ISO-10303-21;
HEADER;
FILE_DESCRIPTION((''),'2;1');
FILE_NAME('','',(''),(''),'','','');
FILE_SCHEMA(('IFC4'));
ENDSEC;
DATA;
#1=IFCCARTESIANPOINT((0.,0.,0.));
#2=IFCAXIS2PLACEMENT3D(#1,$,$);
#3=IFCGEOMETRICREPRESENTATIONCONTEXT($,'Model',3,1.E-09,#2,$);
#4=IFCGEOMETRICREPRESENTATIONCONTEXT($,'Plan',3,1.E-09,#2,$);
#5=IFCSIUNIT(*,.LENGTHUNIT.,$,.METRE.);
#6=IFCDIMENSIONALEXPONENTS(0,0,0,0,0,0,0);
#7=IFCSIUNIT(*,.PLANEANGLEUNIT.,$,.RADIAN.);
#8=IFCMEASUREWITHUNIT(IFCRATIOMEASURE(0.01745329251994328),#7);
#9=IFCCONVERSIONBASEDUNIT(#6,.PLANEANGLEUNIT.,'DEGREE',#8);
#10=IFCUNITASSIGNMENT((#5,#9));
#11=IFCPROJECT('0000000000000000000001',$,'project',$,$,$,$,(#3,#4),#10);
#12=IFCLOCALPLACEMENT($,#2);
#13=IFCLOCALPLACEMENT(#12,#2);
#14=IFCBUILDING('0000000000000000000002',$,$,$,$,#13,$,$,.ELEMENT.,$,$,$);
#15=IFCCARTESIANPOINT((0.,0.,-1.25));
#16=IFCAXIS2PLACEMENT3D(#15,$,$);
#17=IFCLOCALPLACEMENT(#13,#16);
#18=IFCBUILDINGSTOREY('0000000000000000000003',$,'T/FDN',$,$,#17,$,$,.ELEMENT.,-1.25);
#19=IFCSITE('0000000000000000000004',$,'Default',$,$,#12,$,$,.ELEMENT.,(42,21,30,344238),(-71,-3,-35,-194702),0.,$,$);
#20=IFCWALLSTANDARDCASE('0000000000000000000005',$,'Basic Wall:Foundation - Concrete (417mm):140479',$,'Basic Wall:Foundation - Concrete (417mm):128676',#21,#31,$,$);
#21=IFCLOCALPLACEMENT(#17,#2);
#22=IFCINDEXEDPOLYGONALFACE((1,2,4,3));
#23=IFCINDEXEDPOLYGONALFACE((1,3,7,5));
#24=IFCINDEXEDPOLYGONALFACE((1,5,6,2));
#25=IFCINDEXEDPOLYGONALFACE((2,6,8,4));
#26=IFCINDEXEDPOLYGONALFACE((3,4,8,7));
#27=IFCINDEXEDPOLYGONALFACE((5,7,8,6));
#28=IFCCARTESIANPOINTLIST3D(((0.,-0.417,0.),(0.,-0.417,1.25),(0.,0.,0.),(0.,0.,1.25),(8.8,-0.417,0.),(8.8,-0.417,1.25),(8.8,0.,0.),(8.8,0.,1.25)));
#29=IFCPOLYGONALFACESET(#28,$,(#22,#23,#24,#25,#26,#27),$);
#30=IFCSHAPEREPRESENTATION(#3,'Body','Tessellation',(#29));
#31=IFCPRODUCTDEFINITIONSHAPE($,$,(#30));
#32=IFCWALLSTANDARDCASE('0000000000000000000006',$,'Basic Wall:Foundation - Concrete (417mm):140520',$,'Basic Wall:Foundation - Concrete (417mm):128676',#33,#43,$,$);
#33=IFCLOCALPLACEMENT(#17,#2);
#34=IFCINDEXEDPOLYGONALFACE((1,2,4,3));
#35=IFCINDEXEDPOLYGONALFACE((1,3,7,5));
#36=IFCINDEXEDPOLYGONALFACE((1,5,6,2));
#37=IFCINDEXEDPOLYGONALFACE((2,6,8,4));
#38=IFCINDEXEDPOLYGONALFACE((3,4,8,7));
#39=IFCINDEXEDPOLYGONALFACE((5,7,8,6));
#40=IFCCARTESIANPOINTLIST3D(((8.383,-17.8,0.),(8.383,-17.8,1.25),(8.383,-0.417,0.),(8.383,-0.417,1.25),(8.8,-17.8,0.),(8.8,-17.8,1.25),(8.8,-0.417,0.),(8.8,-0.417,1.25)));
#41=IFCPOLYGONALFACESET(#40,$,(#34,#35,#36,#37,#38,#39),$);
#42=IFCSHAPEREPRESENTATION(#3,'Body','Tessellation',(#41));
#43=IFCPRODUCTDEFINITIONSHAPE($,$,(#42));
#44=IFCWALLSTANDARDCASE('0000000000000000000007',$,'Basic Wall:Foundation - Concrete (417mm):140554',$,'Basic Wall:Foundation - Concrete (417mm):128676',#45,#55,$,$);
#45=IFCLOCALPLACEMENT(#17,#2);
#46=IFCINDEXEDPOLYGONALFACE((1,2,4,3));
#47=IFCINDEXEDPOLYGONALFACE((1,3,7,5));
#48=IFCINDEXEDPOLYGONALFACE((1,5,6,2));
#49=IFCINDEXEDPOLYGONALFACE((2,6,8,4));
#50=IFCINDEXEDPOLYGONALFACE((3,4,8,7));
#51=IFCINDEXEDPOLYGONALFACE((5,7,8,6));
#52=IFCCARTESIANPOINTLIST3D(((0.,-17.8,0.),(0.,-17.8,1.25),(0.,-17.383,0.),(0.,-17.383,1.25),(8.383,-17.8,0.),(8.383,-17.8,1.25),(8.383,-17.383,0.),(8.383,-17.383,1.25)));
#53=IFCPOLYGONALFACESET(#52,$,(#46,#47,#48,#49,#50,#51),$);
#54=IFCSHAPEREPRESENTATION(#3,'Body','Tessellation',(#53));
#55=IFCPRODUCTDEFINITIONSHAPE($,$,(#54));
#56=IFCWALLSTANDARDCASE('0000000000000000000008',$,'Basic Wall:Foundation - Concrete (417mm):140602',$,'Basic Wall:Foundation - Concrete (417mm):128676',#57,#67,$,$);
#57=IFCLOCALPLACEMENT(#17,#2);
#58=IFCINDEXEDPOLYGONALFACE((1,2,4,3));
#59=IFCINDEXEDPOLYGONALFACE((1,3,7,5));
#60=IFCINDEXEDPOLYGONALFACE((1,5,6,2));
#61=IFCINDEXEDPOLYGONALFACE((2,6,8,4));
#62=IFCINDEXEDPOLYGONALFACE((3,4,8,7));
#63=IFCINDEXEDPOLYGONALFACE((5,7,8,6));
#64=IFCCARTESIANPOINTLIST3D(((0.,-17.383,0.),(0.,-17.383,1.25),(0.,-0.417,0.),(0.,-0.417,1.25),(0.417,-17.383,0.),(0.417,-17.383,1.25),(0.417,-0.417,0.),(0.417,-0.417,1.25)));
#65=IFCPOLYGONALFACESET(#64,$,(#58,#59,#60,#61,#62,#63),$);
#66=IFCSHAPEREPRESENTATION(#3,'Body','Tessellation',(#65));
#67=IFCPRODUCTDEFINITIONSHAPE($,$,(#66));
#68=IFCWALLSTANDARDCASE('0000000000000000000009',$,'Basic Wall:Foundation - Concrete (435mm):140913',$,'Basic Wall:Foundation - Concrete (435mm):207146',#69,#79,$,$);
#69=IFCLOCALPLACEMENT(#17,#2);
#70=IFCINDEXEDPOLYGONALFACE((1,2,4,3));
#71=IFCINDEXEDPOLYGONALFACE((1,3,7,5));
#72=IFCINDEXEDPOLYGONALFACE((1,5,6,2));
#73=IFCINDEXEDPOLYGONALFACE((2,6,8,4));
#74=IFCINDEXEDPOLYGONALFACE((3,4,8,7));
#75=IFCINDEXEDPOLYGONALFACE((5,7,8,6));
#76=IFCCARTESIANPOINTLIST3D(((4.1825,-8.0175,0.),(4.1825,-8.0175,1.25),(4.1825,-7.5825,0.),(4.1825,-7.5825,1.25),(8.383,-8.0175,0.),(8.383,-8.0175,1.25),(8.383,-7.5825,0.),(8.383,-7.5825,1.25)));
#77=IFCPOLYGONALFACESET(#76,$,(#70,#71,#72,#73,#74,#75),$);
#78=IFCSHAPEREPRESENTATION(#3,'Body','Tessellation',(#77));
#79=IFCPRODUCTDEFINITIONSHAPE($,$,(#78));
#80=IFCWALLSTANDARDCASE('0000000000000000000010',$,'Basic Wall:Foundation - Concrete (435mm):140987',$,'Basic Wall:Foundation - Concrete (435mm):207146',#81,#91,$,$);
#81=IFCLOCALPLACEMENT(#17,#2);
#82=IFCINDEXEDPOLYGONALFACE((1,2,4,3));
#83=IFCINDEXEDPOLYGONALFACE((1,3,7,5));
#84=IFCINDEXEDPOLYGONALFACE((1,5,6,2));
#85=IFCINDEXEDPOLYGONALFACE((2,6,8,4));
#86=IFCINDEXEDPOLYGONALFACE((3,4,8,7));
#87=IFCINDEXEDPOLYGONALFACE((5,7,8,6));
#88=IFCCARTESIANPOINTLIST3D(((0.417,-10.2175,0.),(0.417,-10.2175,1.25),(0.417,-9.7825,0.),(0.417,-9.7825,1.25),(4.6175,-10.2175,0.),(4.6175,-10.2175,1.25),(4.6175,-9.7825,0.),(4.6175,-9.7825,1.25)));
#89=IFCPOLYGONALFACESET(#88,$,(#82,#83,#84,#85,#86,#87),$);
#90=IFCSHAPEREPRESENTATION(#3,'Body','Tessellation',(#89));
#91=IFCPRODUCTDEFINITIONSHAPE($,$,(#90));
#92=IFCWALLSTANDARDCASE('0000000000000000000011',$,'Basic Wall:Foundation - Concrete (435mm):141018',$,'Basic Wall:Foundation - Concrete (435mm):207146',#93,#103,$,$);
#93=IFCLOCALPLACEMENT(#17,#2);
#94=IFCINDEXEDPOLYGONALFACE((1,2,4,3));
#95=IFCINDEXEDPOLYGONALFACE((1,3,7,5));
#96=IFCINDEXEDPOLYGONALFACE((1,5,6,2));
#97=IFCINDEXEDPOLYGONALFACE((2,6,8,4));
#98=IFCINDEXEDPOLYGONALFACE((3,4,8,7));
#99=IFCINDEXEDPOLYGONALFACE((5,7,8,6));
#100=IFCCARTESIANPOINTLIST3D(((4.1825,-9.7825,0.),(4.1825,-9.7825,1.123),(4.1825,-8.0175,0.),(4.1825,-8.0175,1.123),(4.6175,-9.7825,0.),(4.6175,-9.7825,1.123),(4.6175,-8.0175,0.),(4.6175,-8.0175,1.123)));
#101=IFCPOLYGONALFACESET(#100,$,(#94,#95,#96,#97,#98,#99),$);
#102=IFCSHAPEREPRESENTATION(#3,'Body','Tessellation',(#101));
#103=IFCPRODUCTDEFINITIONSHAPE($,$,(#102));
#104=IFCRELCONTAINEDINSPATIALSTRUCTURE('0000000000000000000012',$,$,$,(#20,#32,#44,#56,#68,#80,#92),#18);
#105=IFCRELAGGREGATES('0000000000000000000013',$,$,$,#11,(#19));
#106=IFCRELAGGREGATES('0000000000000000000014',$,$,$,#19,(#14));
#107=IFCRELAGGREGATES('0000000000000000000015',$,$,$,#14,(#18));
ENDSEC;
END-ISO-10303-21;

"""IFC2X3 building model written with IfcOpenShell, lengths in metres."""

from ifc_helpers import new_model, entity, si_unit, converted_unit, frame, frame_2d, origin, place, context, project, spatial, rectangle, extrude, element, save


model = new_model("IFC2X3")

# Units and contexts
model_context = context("Model", 3, precision=1e-09, world=origin())
plan_context = context("Plan", 3, precision=1e-09, world=origin())
ifc_project = project(units=[si_unit("LENGTHUNIT", "METRE"), converted_unit("PLANEANGLEUNIT", "DEGREE", entity("IfcRatioMeasure", 0.01745329251994328), si_unit("PLANEANGLEUNIT", "RADIAN"), dimensions=[0, 0, 0, 0, 0, 0, 0])], contexts=[model_context, plan_context])

# Site, building, storey
site_placement = place(None, origin())
site = spatial("IfcSite", under=ifc_project, at=site_placement, Name="Default", CompositionType="ELEMENT", RefLatitude=(42, 21, 30, 344238), RefLongitude=(-71, -3, -35, -194702), RefElevation=0.0)
building_placement = place(site_placement, origin())
building = spatial("IfcBuilding", under=site, at=building_placement, CompositionType="ELEMENT")
storey_placement = place(building_placement, frame((0.0, 0.0, -1.25)))
storey = spatial("IfcBuildingStorey", under=building, at=storey_placement, Name="T/FDN", CompositionType="ELEMENT", Elevation=-1.25)

# Walls
wall_1_placement = place(storey_placement, frame((0.0, -0.2085, 0.0)))
element("IfcWallStandardCase", 1, at=wall_1_placement, inside=storey, Name="Basic Wall:Foundation - Concrete (417mm):140479", ObjectType="Basic Wall:Foundation - Concrete (417mm):128676", context=model_context, shape_type="SweptSolid", body=[
    extrude(rectangle(XDim=8.8, YDim=0.417, at=frame_2d((4.4, 0.0), x_axis=(-1.0, 0.0))), origin(), (0.0, 0.0, 1.0), 1.25),
])
wall_2_placement = place(storey_placement, frame((8.5915, -0.417, 0.0), z_axis=(0.0, 0.0, 1.0), x_axis=(0.0, -1.0, 0.0)))
element("IfcWallStandardCase", 2, at=wall_2_placement, inside=storey, Name="Basic Wall:Foundation - Concrete (417mm):140520", ObjectType="Basic Wall:Foundation - Concrete (417mm):128676", context=model_context, shape_type="SweptSolid", body=[
    extrude(rectangle(XDim=17.383, YDim=0.417, at=frame_2d((8.6915, 0.0), x_axis=(-1.0, 0.0))), origin(), (0.0, 0.0, 1.0), 1.25),
])
wall_3_placement = place(storey_placement, frame((8.383, -17.5915, 0.0), z_axis=(0.0, 0.0, 1.0), x_axis=(-1.0, 0.0, 0.0)))
element("IfcWallStandardCase", 3, at=wall_3_placement, inside=storey, Name="Basic Wall:Foundation - Concrete (417mm):140554", ObjectType="Basic Wall:Foundation - Concrete (417mm):128676", context=model_context, shape_type="SweptSolid", body=[
    extrude(rectangle(XDim=8.383, YDim=0.417, at=frame_2d((4.1915, 0.0), x_axis=(-1.0, 0.0))), origin(), (0.0, 0.0, 1.0), 1.25),
])
wall_4_placement = place(storey_placement, frame((0.2085, -17.383, 0.0), z_axis=(0.0, 0.0, 1.0), x_axis=(0.0, 1.0, 0.0)))
element("IfcWallStandardCase", 4, at=wall_4_placement, inside=storey, Name="Basic Wall:Foundation - Concrete (417mm):140602", ObjectType="Basic Wall:Foundation - Concrete (417mm):128676", context=model_context, shape_type="SweptSolid", body=[
    extrude(rectangle(XDim=16.966, YDim=0.417, at=frame_2d((8.483, 0.0), x_axis=(-1.0, 0.0))), origin(), (0.0, 0.0, 1.0), 1.25),
])
wall_5_placement = place(storey_placement, frame((8.383, -7.8, 0.0), z_axis=(0.0, 0.0, 1.0), x_axis=(-1.0, 0.0, 0.0)))
element("IfcWallStandardCase", 5, at=wall_5_placement, inside=storey, Name="Basic Wall:Foundation - Concrete (435mm):140913", ObjectType="Basic Wall:Foundation - Concrete (435mm):207146", context=model_context, shape_type="SweptSolid", body=[
    extrude(rectangle(XDim=4.2005, YDim=0.435, at=frame_2d((2.1002, 0.0), x_axis=(-1.0, 0.0))), origin(), (0.0, 0.0, 1.0), 1.25),
])
wall_6_placement = place(storey_placement, frame((0.417, -10.0, 0.0)))
element("IfcWallStandardCase", 6, at=wall_6_placement, inside=storey, Name="Basic Wall:Foundation - Concrete (435mm):140987", ObjectType="Basic Wall:Foundation - Concrete (435mm):207146", context=model_context, shape_type="SweptSolid", body=[
    extrude(rectangle(XDim=4.2005, YDim=0.435, at=frame_2d((2.1002, 0.0), x_axis=(-1.0, 0.0))), origin(), (0.0, 0.0, 1.0), 1.25),
])
wall_7_placement = place(storey_placement, frame((4.4, -9.7825, 0.0), z_axis=(0.0, 0.0, 1.0), x_axis=(0.0, 1.0, 0.0)))
element("IfcWallStandardCase", 7, at=wall_7_placement, inside=storey, Name="Basic Wall:Foundation - Concrete (435mm):141018", ObjectType="Basic Wall:Foundation - Concrete (435mm):207146", context=model_context, shape_type="SweptSolid", body=[
    extrude(rectangle(XDim=1.765, YDim=0.435, at=frame_2d((0.8825, 0.0), x_axis=(-1.0, 0.0))), origin(), (0.0, 0.0, 1.0), 1.123),
])

save(model, "model.ifc")
